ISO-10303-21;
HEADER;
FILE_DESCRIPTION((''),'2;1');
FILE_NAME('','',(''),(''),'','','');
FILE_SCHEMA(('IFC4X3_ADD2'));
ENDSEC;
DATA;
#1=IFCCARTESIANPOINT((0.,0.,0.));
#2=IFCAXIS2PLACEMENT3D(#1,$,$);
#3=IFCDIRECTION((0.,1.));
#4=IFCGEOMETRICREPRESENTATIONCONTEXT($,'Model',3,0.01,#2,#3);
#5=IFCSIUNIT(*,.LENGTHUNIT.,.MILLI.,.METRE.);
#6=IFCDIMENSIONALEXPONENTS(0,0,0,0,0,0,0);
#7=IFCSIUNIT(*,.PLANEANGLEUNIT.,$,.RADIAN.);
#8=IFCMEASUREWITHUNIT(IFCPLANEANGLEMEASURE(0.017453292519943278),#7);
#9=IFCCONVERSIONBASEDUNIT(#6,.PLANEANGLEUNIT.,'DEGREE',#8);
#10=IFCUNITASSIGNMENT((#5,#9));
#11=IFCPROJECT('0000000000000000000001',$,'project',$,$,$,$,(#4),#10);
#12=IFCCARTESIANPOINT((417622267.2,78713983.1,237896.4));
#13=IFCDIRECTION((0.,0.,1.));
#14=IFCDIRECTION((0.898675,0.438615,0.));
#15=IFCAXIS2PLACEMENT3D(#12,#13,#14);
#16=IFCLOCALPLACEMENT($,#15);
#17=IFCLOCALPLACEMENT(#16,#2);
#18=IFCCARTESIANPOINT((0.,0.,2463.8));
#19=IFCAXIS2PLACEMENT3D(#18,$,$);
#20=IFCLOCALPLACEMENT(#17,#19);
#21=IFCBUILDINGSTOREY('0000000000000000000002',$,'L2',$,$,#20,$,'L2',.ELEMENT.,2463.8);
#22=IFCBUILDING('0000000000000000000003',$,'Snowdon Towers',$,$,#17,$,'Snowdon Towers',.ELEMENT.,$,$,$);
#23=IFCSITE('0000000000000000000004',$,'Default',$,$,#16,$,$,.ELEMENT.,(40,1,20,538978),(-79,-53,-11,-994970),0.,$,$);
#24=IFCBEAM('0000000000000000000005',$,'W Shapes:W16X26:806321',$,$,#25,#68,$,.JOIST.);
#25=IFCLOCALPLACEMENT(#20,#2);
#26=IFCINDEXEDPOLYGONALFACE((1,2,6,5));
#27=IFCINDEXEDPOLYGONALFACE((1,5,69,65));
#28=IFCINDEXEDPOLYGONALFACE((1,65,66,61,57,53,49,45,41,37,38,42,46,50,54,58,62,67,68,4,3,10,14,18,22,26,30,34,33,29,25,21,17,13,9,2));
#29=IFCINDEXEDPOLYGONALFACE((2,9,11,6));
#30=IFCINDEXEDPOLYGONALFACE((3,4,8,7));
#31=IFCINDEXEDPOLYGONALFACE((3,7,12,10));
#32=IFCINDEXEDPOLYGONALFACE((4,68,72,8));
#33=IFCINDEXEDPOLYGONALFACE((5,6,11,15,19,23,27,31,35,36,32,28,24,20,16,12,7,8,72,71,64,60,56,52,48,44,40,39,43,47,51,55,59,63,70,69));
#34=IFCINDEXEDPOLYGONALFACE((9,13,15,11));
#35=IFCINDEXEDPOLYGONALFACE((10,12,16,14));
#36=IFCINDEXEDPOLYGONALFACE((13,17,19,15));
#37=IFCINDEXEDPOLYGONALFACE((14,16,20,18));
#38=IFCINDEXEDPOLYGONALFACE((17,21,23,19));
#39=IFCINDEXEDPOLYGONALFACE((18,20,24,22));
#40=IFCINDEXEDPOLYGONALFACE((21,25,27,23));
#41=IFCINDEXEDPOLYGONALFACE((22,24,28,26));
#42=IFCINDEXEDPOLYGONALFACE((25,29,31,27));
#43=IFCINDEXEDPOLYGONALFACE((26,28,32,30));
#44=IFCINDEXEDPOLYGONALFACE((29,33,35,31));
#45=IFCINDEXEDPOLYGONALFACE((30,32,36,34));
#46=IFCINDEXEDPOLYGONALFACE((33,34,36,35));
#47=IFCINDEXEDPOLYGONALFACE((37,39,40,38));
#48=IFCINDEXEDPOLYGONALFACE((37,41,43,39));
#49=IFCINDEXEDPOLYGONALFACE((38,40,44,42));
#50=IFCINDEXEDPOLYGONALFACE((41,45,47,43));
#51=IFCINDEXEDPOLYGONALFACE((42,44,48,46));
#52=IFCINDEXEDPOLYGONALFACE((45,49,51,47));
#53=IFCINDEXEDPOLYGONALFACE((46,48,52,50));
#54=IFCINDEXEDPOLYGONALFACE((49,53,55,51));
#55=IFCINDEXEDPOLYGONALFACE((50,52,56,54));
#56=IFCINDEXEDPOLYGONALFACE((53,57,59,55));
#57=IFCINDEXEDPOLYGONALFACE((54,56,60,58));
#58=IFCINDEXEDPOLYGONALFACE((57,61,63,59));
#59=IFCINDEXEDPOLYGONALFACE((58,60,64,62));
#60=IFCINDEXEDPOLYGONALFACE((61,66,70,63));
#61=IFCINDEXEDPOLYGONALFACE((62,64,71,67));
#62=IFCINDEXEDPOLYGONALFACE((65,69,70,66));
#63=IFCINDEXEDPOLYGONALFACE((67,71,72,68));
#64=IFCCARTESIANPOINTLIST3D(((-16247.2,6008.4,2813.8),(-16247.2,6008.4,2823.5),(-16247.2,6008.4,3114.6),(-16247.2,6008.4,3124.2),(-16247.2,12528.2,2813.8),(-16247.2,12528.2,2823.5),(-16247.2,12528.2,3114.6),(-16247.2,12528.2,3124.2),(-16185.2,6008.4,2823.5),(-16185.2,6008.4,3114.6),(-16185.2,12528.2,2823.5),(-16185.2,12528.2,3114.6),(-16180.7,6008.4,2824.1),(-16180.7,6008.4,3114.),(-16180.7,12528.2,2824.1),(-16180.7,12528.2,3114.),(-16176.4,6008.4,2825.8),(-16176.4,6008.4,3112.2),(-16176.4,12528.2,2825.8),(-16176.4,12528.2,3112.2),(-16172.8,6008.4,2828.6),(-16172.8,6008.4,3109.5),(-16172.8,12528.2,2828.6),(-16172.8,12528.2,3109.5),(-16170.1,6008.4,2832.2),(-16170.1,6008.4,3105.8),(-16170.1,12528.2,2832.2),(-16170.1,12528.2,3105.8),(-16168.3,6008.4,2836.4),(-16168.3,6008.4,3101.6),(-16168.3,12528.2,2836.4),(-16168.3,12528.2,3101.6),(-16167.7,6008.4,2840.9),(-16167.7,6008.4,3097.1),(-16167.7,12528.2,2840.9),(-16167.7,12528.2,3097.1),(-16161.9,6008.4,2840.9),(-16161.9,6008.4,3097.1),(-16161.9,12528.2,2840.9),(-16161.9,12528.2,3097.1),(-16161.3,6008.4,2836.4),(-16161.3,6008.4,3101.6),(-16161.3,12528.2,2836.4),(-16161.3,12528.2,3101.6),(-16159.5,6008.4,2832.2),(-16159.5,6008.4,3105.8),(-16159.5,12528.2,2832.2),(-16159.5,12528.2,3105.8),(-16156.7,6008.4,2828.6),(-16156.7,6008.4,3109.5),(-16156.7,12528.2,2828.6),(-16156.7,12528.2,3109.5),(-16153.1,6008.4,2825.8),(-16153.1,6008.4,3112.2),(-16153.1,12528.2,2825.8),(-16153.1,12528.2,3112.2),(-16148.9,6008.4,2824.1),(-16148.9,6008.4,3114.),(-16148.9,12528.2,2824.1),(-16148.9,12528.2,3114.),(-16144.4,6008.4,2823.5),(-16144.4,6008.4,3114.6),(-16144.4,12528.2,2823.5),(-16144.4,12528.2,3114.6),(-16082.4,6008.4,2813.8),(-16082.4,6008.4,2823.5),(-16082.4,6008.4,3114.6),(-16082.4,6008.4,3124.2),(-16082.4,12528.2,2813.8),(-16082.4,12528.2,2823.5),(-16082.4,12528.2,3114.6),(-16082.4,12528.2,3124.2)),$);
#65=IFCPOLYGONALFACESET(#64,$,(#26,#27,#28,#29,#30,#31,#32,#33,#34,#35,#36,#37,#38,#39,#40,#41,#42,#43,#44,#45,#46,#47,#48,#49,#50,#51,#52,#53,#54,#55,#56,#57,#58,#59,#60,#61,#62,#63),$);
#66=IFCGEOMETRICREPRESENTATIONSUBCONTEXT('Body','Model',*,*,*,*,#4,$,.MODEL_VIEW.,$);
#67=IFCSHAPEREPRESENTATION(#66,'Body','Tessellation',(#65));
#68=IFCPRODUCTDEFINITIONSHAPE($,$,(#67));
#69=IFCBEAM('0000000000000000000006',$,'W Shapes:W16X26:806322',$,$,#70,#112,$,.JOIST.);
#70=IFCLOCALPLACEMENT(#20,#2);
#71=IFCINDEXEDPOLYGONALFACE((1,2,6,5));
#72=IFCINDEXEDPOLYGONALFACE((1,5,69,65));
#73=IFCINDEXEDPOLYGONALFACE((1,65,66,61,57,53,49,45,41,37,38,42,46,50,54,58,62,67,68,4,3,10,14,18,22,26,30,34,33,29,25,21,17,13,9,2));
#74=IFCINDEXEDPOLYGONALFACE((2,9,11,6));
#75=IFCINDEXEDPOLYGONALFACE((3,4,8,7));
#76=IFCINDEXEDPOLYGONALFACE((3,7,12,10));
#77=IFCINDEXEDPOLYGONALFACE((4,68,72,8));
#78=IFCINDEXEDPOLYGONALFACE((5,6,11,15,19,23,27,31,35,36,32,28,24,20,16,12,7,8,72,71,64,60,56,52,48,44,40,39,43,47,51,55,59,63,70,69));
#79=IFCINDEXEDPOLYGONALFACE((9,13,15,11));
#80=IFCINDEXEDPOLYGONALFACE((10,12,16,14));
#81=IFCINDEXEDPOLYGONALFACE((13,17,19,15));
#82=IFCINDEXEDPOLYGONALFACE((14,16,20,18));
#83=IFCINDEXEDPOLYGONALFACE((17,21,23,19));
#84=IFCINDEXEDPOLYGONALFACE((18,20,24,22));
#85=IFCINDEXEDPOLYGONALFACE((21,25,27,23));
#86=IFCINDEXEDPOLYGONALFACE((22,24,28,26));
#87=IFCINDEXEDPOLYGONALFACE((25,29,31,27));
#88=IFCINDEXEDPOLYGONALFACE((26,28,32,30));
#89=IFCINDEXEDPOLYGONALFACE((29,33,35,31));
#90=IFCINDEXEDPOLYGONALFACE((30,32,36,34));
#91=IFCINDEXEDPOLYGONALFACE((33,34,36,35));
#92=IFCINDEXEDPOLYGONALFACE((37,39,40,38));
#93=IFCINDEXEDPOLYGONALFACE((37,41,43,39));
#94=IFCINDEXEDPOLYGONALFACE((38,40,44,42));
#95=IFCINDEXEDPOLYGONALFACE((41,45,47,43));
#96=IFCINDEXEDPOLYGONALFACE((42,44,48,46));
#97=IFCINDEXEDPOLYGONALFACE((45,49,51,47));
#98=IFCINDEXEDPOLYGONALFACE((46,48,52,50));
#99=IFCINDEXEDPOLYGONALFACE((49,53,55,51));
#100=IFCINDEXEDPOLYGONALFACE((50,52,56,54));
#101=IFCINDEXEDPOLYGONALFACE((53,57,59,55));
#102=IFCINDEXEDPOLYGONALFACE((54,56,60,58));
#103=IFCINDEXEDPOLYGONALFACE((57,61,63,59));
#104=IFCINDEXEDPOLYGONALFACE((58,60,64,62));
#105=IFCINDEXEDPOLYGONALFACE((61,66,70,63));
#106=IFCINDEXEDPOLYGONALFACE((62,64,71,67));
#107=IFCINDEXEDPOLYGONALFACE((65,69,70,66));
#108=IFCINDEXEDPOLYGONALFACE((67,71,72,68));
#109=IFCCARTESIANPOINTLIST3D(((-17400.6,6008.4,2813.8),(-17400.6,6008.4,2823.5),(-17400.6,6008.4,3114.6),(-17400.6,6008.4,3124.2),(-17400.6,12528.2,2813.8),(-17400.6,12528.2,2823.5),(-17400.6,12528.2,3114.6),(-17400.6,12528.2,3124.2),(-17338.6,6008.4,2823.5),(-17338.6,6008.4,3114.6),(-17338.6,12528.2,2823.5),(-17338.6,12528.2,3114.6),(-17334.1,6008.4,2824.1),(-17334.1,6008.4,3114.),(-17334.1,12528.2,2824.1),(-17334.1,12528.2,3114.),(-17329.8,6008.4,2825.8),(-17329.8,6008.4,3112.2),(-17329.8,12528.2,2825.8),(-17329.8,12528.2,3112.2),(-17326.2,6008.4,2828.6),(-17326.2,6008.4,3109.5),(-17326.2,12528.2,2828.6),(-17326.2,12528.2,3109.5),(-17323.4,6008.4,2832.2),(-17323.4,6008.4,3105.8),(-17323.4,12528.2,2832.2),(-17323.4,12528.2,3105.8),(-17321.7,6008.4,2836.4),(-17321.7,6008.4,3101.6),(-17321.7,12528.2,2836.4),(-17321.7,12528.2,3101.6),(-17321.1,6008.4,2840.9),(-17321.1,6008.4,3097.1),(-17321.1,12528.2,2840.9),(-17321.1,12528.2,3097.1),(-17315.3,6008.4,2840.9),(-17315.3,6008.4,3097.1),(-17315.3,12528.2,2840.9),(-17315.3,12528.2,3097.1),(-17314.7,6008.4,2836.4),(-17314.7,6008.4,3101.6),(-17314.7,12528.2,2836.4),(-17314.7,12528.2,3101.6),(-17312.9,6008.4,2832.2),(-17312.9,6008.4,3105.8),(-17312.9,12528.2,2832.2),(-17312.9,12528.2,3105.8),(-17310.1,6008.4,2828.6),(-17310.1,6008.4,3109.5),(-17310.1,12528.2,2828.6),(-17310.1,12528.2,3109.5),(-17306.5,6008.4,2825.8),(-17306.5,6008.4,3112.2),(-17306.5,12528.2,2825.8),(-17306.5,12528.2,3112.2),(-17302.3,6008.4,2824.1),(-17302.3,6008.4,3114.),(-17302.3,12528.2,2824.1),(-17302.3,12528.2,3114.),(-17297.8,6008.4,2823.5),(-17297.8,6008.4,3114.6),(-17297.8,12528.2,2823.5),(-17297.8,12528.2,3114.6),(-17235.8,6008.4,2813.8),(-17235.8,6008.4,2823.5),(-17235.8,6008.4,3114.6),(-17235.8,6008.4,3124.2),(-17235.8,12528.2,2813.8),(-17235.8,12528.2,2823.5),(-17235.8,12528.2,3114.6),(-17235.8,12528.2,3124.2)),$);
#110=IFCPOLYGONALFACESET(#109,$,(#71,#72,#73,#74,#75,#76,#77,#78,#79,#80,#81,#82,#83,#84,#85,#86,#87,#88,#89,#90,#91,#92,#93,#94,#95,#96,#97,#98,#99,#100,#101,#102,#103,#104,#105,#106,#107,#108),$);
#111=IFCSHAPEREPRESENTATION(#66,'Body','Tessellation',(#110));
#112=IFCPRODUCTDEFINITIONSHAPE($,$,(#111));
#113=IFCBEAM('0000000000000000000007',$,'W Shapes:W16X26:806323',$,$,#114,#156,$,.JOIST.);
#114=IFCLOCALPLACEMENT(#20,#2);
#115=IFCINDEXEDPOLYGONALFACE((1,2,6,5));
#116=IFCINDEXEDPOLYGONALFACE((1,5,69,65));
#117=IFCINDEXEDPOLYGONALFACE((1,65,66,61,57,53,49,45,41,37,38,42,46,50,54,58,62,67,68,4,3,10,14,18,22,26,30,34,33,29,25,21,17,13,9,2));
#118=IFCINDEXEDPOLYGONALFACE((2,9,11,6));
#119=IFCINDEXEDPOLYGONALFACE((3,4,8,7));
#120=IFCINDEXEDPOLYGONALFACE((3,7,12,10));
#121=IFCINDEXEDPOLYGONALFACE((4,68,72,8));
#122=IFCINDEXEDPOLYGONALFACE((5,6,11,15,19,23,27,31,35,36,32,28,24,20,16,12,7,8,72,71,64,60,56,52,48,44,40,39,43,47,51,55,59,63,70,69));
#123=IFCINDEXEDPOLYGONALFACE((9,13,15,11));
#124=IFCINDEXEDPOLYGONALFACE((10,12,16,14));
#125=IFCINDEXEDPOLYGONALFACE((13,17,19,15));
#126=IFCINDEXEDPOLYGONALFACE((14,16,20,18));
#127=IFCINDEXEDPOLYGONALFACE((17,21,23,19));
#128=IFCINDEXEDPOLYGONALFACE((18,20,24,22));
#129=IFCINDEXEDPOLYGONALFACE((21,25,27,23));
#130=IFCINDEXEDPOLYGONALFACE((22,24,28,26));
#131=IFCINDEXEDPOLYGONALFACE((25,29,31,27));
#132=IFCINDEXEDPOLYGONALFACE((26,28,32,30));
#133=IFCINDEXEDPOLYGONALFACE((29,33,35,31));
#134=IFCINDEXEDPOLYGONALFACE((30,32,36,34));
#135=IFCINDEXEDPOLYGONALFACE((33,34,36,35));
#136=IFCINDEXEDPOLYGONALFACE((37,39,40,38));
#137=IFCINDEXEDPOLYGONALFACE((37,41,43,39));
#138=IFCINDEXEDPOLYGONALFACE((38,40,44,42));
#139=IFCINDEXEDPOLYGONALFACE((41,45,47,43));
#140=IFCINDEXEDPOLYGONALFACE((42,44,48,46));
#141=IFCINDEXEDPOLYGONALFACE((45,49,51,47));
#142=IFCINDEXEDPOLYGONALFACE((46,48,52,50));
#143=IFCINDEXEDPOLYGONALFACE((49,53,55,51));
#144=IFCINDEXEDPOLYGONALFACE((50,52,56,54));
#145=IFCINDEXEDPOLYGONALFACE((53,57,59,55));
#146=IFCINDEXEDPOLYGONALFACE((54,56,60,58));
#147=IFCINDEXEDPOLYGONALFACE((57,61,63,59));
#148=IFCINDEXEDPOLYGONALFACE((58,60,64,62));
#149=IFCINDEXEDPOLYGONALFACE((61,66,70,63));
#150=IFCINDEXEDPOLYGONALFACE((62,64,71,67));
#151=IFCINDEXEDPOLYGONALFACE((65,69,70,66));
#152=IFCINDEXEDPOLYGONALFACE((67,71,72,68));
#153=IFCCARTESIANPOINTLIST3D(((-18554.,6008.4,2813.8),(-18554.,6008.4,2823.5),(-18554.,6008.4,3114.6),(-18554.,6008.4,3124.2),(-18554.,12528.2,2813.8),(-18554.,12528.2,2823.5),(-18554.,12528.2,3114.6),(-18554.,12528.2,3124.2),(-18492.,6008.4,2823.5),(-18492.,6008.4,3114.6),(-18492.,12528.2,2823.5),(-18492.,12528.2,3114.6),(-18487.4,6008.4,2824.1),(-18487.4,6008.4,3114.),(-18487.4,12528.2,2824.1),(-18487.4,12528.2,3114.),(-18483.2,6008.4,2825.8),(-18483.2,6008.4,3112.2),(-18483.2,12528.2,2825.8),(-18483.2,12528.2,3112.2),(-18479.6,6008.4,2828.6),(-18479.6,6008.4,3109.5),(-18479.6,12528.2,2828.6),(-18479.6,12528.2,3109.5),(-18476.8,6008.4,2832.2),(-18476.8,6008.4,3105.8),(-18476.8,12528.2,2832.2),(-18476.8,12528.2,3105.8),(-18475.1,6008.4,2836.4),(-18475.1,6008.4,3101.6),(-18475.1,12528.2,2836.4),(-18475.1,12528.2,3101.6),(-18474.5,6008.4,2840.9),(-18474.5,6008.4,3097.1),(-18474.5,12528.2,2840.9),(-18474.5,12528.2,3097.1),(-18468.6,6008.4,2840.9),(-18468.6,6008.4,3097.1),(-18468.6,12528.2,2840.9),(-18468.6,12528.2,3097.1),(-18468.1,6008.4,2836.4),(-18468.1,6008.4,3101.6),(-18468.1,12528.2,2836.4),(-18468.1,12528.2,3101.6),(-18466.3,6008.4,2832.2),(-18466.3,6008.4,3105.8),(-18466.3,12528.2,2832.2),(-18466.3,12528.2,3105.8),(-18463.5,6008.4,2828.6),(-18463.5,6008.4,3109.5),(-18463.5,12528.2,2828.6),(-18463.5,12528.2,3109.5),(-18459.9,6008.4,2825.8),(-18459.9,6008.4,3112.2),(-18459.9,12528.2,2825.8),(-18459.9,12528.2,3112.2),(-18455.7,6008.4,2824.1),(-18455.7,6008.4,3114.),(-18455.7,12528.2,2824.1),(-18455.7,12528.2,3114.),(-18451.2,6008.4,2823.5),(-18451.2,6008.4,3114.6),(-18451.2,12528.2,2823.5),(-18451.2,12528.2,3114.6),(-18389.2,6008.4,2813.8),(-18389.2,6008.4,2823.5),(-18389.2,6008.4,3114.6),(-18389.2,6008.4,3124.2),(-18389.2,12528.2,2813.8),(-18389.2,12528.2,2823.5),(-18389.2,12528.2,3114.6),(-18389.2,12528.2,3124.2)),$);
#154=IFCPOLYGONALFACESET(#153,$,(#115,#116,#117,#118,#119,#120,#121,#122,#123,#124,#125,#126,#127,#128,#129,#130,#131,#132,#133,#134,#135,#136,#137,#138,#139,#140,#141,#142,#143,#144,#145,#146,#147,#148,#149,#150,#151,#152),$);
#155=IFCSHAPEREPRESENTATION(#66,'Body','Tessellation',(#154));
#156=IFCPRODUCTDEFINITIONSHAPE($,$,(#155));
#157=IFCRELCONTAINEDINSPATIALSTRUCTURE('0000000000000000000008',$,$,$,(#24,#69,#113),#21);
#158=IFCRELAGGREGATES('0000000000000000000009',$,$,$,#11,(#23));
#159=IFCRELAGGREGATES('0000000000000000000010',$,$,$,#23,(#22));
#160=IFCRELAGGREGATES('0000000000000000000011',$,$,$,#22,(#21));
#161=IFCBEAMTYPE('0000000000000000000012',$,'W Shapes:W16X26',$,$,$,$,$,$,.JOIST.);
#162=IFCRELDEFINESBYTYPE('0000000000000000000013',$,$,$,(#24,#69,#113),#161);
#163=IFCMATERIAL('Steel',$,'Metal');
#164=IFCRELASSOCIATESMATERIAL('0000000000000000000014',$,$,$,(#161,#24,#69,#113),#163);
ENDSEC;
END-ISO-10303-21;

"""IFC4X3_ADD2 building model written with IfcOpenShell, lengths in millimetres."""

from ifc_helpers import new_model, entity, si_unit, converted_unit, direction, frame, frame_2d, origin, place, context, subcontext, project, spatial, polyline, circle_curve, parameter, trimmed, segment, composite_curve, outline, extrude, source, transform, mapped, material, material_profile, profile_set, profile_usage, type_object, type_shapes, element, save


model = new_model("IFC4X3_ADD2")

# Units and contexts
model_context = context("Model", 3, precision=0.01, world=origin(), true_north=direction((0.0, 1.0)))
body_context = subcontext(model_context, "Body", "Model", "MODEL_VIEW")
ifc_project = project(units=[si_unit("LENGTHUNIT", "METRE", prefix="MILLI"), converted_unit("PLANEANGLEUNIT", "DEGREE", entity("IfcPlaneAngleMeasure", 0.017453292519943278), si_unit("PLANEANGLEUNIT", "RADIAN"), dimensions=[0, 0, 0, 0, 0, 0, 0])], contexts=[model_context])

# Site, building, storey
site_placement = place(None, frame((417622267.2, 78713983.1, 237896.4), z_axis=(0.0, 0.0, 1.0), x_axis=(0.898675, 0.438615, 0.0)))
site = spatial("IfcSite", under=ifc_project, at=site_placement, Name="Default", CompositionType="ELEMENT", RefLatitude=(40, 1, 20, 538978), RefLongitude=(-79, -53, -11, -994970), RefElevation=0.0)
building_placement = place(site_placement, origin())
building = spatial("IfcBuilding", under=site, at=building_placement, Name="Snowdon Towers", LongName="Snowdon Towers", CompositionType="ELEMENT")
storey_placement = place(building_placement, frame((0.0, 0.0, 2463.8)))
storey = spatial("IfcBuildingStorey", under=building, at=storey_placement, Name="L2", LongName="L2", CompositionType="ELEMENT", Elevation=2463.8)

# Beams
ifc_material_1 = material(Name="Steel", Category="Metal")
ifc_material_profile_1 = material_profile(ifc_material_1, outline(composite_curve([segment(polyline([(-82.4, -145.6), (-82.4, -155.2)]), True, "CONTINUOUS"), segment(polyline([(-82.4, -155.2), (82.4, -155.2)]), True, "CONTINUOUS"), segment(polyline([(82.4, -155.2), (82.4, -145.6)]), True, "CONTINUOUS"), segment(polyline([(82.4, -145.6), (20.4, -145.6)]), True, "CONTINUOUS"), segment(trimmed(circle_curve(frame_2d((20.4, -128.1), x_axis=(1.0, 0.0)), 17.5), [parameter(180.0)], [parameter(270.0)], True, "PARAMETER"), False, "CONTINUOUS"), segment(polyline([(2.9, -128.1), (2.9, 128.1)]), True, "CONTINUOUS"), segment(trimmed(circle_curve(frame_2d((20.4, 128.1), x_axis=(1.0, 0.0)), 17.5), [parameter(90.0)], [parameter(180.0)], True, "PARAMETER"), False, "CONTINUOUS"), segment(polyline([(20.4, 145.6), (82.4, 145.6)]), True, "CONTINUOUS"), segment(polyline([(82.4, 145.6), (82.4, 155.2)]), True, "CONTINUOUS"), segment(polyline([(82.4, 155.2), (-82.4, 155.2)]), True, "CONTINUOUS"), segment(polyline([(-82.4, 155.2), (-82.4, 145.6)]), True, "CONTINUOUS"), segment(polyline([(-82.4, 145.6), (-20.4, 145.6)]), True, "CONTINUOUS"), segment(trimmed(circle_curve(frame_2d((-20.4, 128.1), x_axis=(1.0, 0.0)), 17.5), [parameter(360.0)], [parameter(90.0)], True, "PARAMETER"), False, "CONTINUOUS"), segment(polyline([(-2.9, 128.1), (-2.9, -128.1)]), True, "CONTINUOUS"), segment(trimmed(circle_curve(frame_2d((-20.4, -128.1), x_axis=(1.0, 0.0)), 17.5), [parameter(270.0)], [parameter(360.0)], True, "PARAMETER"), False, "CONTINUOUS"), segment(polyline([(-20.4, -145.6), (-82.4, -145.6)]), True, "CONTINUOUS")], self_intersect=False)), Name="W16X26")
ifc_profile_set_1 = profile_set([ifc_material_profile_1], Name="W16X26")
ifc_profile_usage_1 = profile_usage(ifc_profile_set_1, cardinal=8)
beam_type_1 = type_object("IfcBeamType", Name="W Shapes:W16X26", PredefinedType="JOIST", material=ifc_profile_set_1)
shared_shape_1 = source(origin(), body_context, "Body", "SweptSolid", [
    extrude(outline(composite_curve([segment(polyline([(-82.4, -145.6), (-82.4, -155.2)]), True, "CONTINUOUS"), segment(polyline([(-82.4, -155.2), (82.4, -155.2)]), True, "CONTINUOUS"), segment(polyline([(82.4, -155.2), (82.4, -145.6)]), True, "CONTINUOUS"), segment(polyline([(82.4, -145.6), (20.4, -145.6)]), True, "CONTINUOUS"), segment(trimmed(circle_curve(frame_2d((20.4, -128.1), x_axis=(1.0, 0.0)), 17.5), [parameter(180.0)], [parameter(270.0)], True, "PARAMETER"), False, "CONTINUOUS"), segment(polyline([(2.9, -128.1), (2.9, 128.1)]), True, "CONTINUOUS"), segment(trimmed(circle_curve(frame_2d((20.4, 128.1), x_axis=(1.0, 0.0)), 17.5), [parameter(90.0)], [parameter(180.0)], True, "PARAMETER"), False, "CONTINUOUS"), segment(polyline([(20.4, 145.6), (82.4, 145.6)]), True, "CONTINUOUS"), segment(polyline([(82.4, 145.6), (82.4, 155.2)]), True, "CONTINUOUS"), segment(polyline([(82.4, 155.2), (-82.4, 155.2)]), True, "CONTINUOUS"), segment(polyline([(-82.4, 155.2), (-82.4, 145.6)]), True, "CONTINUOUS"), segment(polyline([(-82.4, 145.6), (-20.4, 145.6)]), True, "CONTINUOUS"), segment(trimmed(circle_curve(frame_2d((-20.4, 128.1), x_axis=(1.0, 0.0)), 17.5), [parameter(360.0)], [parameter(90.0)], True, "PARAMETER"), False, "CONTINUOUS"), segment(polyline([(-2.9, 128.1), (-2.9, -128.1)]), True, "CONTINUOUS"), segment(trimmed(circle_curve(frame_2d((-20.4, -128.1), x_axis=(1.0, 0.0)), 17.5), [parameter(270.0)], [parameter(360.0)], True, "PARAMETER"), False, "CONTINUOUS"), segment(polyline([(-20.4, -145.6), (-82.4, -145.6)]), True, "CONTINUOUS")], self_intersect=False)), frame((-3282.6, 0.0, 0.0), z_axis=(-1.0, 0.0, 0.0), x_axis=(0.0, -1.0, 0.0)), (0.0, 0.0, -1.0), 6519.8),
])
type_shapes(beam_type_1, [shared_shape_1])
for number, where, z_axis, x_axis, name in (
    (1, (-16164.8, 9245.6, 2969.0), (0.0, 0.0, 1.0), (0.0, -1.0, 0.0), "W Shapes:W16X26:806321"),
    (2, (-17318.2, 9245.6, 2969.0), (0.0, 0.0, 1.0), (0.0, -1.0, 0.0), "W Shapes:W16X26:806322"),
    (3, (-18471.6, 9245.6, 2969.0), (0.0, 0.0, 1.0), (0.0, -1.0, 0.0), "W Shapes:W16X26:806323"),
):
    element("IfcBeam", number, at=place(storey_placement, frame(where, z_axis=z_axis, x_axis=x_axis)), inside=storey, type_object=beam_type_1, material=ifc_profile_usage_1, Name=name, PredefinedType="JOIST", context=body_context, shape_type="MappedRepresentation", body=[
        mapped(shared_shape_1, transform((0.0, 0.0, 0.0), scale=1.0)),
    ])

save(model, "model.ifc")
